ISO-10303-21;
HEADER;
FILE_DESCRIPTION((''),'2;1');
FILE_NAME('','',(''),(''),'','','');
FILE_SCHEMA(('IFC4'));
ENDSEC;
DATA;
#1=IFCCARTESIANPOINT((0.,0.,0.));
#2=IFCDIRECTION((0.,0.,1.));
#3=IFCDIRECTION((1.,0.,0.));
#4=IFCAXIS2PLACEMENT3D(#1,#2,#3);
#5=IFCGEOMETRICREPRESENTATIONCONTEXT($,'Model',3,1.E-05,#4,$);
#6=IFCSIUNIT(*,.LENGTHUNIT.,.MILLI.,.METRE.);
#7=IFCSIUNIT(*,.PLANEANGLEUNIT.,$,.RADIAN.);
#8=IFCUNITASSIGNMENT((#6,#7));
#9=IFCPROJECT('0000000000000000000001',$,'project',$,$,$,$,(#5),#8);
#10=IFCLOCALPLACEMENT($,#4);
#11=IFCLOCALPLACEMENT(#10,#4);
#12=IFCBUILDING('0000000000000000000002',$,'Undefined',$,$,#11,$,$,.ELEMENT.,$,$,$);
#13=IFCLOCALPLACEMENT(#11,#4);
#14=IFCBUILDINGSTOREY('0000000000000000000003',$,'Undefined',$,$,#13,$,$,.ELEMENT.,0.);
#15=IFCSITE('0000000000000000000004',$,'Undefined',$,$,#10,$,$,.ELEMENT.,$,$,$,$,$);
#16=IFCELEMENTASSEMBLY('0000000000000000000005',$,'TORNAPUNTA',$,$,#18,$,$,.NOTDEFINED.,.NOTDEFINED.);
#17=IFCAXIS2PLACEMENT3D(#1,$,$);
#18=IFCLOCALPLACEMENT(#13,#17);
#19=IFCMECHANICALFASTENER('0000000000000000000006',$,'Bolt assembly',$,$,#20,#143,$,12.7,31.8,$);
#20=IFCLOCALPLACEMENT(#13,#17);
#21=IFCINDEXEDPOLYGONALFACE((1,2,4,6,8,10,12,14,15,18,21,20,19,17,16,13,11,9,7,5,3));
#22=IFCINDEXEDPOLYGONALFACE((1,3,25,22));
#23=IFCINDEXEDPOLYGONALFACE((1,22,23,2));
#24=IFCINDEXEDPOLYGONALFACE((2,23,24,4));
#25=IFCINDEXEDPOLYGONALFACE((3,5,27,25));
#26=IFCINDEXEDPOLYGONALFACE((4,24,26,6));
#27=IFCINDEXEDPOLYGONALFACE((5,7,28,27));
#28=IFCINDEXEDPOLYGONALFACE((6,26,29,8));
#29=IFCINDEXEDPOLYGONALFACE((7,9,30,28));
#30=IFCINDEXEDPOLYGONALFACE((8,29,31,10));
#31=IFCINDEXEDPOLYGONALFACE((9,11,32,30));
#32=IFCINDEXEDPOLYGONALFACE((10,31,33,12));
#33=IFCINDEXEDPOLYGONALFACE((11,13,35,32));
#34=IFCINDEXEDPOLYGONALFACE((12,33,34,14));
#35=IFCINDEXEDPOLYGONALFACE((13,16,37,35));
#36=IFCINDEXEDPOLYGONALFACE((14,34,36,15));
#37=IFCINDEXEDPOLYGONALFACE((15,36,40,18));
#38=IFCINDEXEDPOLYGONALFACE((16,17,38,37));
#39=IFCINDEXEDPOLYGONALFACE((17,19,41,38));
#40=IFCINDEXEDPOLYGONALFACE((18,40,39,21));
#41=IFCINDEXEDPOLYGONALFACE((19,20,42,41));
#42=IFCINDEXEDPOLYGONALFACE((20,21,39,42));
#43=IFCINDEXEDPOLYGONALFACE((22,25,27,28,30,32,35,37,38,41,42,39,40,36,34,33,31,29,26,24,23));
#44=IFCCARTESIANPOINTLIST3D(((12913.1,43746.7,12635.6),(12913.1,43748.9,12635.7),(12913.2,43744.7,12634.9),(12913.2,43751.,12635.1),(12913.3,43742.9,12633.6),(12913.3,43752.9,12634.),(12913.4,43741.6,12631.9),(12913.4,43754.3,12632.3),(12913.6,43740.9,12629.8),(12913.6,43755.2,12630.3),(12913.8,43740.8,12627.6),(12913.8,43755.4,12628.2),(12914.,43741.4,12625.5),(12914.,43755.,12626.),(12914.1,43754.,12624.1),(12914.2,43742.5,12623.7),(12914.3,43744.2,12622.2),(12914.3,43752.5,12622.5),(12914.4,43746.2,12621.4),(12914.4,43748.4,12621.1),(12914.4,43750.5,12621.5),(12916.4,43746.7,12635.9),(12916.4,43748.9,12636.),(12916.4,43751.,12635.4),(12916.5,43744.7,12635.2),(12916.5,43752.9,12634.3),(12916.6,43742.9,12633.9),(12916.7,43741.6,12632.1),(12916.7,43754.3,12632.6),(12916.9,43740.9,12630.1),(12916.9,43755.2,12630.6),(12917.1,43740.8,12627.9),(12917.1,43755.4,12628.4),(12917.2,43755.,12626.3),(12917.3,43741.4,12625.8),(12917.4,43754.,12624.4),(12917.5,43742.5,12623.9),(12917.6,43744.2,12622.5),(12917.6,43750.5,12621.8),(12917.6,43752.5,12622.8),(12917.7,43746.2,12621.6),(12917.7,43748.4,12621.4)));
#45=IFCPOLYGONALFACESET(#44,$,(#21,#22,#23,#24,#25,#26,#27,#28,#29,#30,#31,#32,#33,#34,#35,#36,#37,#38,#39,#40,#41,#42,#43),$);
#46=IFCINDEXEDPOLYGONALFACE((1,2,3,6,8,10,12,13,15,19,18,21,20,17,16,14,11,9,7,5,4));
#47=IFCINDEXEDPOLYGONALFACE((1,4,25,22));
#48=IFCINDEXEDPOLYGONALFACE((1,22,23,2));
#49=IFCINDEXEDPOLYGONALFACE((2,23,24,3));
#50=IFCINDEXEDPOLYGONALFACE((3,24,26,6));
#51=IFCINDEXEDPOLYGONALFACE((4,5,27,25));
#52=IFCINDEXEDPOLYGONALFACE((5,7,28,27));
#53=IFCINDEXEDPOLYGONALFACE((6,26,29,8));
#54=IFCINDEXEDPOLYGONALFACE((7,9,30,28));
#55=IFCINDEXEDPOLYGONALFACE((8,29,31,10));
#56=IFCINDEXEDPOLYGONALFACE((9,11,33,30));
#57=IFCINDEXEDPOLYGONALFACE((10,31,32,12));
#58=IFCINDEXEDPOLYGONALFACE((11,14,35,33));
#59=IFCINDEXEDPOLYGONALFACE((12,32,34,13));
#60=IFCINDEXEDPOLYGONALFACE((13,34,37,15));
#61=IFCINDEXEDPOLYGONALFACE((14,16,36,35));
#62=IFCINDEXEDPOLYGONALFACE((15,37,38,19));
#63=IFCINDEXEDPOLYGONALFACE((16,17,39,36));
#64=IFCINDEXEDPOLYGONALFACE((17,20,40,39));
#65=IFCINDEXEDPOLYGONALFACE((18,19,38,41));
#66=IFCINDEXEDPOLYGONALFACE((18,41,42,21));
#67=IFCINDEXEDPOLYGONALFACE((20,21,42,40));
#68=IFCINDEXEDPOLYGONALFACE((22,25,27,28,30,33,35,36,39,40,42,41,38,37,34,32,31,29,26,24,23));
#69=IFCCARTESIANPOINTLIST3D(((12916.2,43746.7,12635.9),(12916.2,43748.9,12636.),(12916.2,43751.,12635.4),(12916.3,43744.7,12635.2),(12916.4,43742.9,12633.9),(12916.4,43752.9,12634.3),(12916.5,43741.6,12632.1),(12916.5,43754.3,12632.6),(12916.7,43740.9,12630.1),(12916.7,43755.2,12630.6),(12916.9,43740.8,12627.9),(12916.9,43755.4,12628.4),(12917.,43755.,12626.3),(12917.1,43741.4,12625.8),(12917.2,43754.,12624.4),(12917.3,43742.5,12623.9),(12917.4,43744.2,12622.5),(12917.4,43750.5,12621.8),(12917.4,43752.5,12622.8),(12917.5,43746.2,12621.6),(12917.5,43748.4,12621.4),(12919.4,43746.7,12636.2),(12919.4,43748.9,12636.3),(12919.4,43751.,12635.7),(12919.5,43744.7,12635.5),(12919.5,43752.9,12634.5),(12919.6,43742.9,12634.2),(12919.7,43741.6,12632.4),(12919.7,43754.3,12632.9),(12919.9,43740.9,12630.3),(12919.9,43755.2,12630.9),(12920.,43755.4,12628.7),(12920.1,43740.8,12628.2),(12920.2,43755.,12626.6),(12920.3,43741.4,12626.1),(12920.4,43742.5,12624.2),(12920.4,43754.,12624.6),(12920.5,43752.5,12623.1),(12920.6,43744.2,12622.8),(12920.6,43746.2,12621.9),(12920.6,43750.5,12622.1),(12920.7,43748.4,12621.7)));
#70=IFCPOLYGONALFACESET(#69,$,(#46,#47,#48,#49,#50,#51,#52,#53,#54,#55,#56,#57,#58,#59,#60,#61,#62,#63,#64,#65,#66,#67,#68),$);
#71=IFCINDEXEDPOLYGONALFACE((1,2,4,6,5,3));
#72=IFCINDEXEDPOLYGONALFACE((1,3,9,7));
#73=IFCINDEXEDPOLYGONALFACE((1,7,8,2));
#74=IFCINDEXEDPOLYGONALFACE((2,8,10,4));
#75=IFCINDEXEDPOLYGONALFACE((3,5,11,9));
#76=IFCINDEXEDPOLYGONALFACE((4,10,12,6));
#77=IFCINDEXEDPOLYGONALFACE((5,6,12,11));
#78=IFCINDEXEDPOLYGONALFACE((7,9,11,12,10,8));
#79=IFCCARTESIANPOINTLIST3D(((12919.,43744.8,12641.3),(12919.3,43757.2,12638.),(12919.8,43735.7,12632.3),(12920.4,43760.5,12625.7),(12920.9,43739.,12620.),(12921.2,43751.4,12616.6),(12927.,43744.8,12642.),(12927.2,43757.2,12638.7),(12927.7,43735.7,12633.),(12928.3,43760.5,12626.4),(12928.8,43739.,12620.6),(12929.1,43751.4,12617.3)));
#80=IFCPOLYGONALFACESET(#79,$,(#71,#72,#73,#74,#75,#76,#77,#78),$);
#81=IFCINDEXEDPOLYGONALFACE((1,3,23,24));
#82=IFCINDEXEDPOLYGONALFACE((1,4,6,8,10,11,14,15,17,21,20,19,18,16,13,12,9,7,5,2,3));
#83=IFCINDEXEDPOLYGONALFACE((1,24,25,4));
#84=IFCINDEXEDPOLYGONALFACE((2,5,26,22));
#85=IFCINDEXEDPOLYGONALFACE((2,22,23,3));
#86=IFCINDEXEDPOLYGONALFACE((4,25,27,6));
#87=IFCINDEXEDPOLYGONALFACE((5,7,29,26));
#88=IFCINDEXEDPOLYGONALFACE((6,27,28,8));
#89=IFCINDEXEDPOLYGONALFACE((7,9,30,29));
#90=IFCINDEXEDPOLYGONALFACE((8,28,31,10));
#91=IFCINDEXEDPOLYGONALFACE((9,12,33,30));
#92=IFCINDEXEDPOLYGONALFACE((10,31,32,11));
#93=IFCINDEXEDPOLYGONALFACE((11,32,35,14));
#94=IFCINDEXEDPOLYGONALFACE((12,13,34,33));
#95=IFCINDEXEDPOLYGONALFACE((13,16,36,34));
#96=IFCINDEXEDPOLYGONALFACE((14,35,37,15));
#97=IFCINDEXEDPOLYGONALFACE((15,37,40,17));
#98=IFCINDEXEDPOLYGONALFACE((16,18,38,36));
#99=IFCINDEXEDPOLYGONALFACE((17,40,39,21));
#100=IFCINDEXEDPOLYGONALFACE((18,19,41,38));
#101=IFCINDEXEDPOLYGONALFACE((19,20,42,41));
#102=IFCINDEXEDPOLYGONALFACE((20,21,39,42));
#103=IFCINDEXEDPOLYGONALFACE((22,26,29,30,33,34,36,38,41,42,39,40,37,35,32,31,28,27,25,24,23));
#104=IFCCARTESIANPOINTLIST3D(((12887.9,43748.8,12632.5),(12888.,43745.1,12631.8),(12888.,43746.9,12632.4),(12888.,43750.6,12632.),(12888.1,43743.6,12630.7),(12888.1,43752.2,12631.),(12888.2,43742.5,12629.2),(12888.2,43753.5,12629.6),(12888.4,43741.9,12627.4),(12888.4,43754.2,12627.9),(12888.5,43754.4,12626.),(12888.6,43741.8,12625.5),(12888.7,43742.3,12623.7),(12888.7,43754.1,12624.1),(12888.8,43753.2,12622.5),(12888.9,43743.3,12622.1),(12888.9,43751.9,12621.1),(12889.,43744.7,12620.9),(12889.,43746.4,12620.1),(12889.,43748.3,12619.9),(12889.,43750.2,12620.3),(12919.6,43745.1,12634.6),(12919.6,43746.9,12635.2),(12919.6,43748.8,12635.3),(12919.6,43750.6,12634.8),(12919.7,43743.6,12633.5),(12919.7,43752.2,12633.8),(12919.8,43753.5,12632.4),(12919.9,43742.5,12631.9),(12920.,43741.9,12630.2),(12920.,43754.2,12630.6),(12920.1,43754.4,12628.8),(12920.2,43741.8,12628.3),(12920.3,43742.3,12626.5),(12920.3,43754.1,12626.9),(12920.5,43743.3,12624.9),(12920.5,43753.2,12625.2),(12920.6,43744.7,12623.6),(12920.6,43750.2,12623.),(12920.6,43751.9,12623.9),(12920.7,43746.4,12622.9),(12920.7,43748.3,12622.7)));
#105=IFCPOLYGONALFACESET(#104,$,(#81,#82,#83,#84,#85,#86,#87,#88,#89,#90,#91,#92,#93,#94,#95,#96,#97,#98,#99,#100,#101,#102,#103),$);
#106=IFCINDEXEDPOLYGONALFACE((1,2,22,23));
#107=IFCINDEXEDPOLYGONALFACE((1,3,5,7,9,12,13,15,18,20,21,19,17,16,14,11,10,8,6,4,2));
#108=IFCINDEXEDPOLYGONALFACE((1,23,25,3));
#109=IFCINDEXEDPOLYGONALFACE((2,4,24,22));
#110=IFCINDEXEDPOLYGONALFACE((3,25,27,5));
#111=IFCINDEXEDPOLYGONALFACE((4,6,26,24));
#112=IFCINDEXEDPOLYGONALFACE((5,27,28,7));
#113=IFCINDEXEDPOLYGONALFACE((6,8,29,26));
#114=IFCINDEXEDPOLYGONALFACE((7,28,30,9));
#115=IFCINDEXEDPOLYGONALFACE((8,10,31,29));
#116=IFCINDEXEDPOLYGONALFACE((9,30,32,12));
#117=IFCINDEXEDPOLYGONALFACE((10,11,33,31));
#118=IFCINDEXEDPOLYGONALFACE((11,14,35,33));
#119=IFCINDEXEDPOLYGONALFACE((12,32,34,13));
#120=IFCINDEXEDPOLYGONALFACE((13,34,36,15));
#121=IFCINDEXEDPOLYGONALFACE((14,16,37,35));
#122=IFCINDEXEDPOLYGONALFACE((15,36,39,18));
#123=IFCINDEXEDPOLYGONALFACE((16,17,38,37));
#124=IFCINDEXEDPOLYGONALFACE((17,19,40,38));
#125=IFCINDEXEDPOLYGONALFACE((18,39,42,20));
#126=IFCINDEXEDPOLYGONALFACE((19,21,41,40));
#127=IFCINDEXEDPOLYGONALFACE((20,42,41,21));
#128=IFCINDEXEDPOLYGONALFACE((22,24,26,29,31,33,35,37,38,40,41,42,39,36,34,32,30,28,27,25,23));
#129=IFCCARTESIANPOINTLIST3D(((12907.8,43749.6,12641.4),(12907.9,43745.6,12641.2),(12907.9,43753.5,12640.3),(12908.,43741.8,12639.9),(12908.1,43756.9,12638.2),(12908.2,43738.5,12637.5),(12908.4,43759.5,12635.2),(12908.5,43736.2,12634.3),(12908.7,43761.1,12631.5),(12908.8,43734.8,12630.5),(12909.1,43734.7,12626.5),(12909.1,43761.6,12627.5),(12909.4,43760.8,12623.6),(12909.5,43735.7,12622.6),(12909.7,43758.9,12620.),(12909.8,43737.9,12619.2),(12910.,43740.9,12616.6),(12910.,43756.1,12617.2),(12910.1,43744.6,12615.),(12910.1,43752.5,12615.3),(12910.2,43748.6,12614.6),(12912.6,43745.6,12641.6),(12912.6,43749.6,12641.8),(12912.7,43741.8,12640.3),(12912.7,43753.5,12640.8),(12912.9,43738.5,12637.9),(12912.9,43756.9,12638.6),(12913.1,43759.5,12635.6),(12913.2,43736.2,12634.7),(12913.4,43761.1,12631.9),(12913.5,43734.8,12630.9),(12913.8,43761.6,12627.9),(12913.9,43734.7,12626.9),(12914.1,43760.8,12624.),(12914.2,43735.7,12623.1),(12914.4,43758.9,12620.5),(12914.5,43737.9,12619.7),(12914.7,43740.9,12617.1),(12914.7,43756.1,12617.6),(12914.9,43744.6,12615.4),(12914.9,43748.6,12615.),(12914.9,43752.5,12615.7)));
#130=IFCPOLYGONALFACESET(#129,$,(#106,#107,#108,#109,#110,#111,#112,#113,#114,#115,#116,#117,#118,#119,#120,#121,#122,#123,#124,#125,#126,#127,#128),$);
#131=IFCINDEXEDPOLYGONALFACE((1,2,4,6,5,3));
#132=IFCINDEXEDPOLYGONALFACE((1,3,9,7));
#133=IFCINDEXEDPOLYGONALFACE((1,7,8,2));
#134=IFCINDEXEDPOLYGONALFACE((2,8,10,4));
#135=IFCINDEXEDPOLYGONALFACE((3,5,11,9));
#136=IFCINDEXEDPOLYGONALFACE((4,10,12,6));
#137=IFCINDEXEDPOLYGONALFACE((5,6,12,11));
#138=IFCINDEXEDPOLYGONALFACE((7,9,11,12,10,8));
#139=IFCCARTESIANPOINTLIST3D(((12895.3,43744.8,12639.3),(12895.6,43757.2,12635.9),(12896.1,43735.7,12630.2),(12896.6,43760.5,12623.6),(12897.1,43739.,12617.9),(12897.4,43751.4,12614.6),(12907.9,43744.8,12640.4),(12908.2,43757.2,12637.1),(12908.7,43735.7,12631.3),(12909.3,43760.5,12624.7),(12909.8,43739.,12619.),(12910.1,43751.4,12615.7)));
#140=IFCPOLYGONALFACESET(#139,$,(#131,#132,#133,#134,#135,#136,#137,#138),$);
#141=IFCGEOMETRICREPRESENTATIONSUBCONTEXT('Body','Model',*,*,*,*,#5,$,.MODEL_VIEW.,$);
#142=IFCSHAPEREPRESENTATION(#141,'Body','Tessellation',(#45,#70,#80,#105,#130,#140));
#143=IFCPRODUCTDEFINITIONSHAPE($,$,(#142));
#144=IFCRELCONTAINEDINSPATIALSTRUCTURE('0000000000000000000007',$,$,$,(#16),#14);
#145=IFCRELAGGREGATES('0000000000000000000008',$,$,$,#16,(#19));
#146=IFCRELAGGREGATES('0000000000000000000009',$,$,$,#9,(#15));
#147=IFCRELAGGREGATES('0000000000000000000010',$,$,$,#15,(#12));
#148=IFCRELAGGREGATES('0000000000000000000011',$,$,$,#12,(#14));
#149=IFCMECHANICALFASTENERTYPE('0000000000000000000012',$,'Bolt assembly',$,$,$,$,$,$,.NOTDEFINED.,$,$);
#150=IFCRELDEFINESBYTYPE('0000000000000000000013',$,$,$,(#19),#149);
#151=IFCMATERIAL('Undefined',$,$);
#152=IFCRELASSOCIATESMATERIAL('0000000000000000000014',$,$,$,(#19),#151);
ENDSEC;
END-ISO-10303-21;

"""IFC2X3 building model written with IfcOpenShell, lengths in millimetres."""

from ifc_helpers import new_model, si_unit, frame, origin_with_axes, origin_2d_with_axis, place, context, subcontext, project, spatial, polyline, circle, outline, extrude, source, transform, mapped, material, type_object, element, aggregate, save


model = new_model("IFC2X3")

# Units and contexts
model_context = context("Model", 3, precision=1e-05, world=origin_with_axes())
body_context = subcontext(model_context, "Body", "Model", "MODEL_VIEW")
ifc_project = project(units=[si_unit("LENGTHUNIT", "METRE", prefix="MILLI"), si_unit("PLANEANGLEUNIT", "RADIAN")], contexts=[model_context])

# Site, building, storey
site_placement = place(None, origin_with_axes())
site = spatial("IfcSite", under=ifc_project, at=site_placement, Name="Undefined", CompositionType="ELEMENT")
building_placement = place(site_placement, origin_with_axes())
building = spatial("IfcBuilding", under=site, at=building_placement, Name="Undefined", CompositionType="ELEMENT")
storey_placement = place(building_placement, origin_with_axes())
storey = spatial("IfcBuildingStorey", under=building, at=storey_placement, Name="Undefined", CompositionType="ELEMENT", Elevation=0.0)

# Shared definitions
ifc_material_1 = material(Name="Undefined")
mechanical_fastener_type = type_object("IfcMechanicalFastenerType", Name="Bolt assembly")
shared_shape_1 = source(origin_with_axes(), body_context, "Body", "SweptSolid", [
    extrude(circle(Radius=7.3, at=origin_2d_with_axis()), frame((0.0, -0.1, 0.0), z_axis=(0.0, 1.0, 0.0), x_axis=(1.0, 0.0, 0.0)), (0.0, 0.0, 1.0), 3.3),
    extrude(circle(Radius=7.3, at=origin_2d_with_axis()), frame((0.0, -3.1, 0.0), z_axis=(0.0, 1.0, 0.0), x_axis=(1.0, 0.0, 0.0)), (0.0, 0.0, 1.0), 3.2),
    extrude(outline(polyline([(11.1, -6.4), (11.1, 6.4), (0.0, 12.8), (-11.1, 6.4), (-11.1, -6.4), (0.0, -12.8), (11.1, -6.4)])), frame((0.0, -11.1, 0.0), z_axis=(0.0, 1.0, 0.0), x_axis=(1.0, 0.0, 0.0)), (0.0, 0.0, 1.0), 7.9),
    extrude(circle(Radius=6.3, at=origin_2d_with_axis()), frame((0.0, -3.2, 0.0), z_axis=(0.0, 1.0, 0.0), x_axis=(1.0, 0.0, 0.0)), (0.0, 0.0, 1.0), 31.8),
    extrude(circle(Radius=13.5, at=origin_2d_with_axis()), frame((0.0, 3.2, 0.0), z_axis=(0.0, 1.0, 0.0), x_axis=(1.0, 0.0, 0.0)), (0.0, 0.0, 1.0), 4.8),
    extrude(outline(polyline([(11.1, -6.4), (11.1, 6.4), (0.0, 12.8), (-11.1, 6.4), (-11.1, -6.4), (0.0, -12.8), (11.1, -6.4)])), frame((0.0, 8.0, 0.0), z_axis=(0.0, 1.0, 0.0), x_axis=(1.0, 0.0, 0.0)), (0.0, 0.0, 1.0), 12.7),
])

# Element assembly, mechanical fastener
assembly_1_placement = place(storey_placement, origin_with_axes())
assembly_1 = element("IfcElementAssembly", 1, at=assembly_1_placement, inside=storey, Name="TORNAPUNTA", AssemblyPlace="NOTDEFINED", PredefinedType="NOTDEFINED")
mechanical_fastener_1_placement = place(assembly_1_placement, frame((12916.9, 43748.1, 12628.7), z_axis=(0.061628, -0.707107, -0.704416), x_axis=(-0.061628, -0.707107, 0.704416)))
mechanical_fastener_1 = element("IfcMechanicalFastener", 2, at=mechanical_fastener_1_placement, type_object=mechanical_fastener_type, material=ifc_material_1, Name="Bolt assembly", NominalDiameter=12.7, NominalLength=31.8, context=body_context, shape_type="MappedRepresentation", body=[
    mapped(shared_shape_1, transform((0.0, 0.0, 0.0))),
])
aggregate(assembly_1, [mechanical_fastener_1])

save(model, "model.ifc")
